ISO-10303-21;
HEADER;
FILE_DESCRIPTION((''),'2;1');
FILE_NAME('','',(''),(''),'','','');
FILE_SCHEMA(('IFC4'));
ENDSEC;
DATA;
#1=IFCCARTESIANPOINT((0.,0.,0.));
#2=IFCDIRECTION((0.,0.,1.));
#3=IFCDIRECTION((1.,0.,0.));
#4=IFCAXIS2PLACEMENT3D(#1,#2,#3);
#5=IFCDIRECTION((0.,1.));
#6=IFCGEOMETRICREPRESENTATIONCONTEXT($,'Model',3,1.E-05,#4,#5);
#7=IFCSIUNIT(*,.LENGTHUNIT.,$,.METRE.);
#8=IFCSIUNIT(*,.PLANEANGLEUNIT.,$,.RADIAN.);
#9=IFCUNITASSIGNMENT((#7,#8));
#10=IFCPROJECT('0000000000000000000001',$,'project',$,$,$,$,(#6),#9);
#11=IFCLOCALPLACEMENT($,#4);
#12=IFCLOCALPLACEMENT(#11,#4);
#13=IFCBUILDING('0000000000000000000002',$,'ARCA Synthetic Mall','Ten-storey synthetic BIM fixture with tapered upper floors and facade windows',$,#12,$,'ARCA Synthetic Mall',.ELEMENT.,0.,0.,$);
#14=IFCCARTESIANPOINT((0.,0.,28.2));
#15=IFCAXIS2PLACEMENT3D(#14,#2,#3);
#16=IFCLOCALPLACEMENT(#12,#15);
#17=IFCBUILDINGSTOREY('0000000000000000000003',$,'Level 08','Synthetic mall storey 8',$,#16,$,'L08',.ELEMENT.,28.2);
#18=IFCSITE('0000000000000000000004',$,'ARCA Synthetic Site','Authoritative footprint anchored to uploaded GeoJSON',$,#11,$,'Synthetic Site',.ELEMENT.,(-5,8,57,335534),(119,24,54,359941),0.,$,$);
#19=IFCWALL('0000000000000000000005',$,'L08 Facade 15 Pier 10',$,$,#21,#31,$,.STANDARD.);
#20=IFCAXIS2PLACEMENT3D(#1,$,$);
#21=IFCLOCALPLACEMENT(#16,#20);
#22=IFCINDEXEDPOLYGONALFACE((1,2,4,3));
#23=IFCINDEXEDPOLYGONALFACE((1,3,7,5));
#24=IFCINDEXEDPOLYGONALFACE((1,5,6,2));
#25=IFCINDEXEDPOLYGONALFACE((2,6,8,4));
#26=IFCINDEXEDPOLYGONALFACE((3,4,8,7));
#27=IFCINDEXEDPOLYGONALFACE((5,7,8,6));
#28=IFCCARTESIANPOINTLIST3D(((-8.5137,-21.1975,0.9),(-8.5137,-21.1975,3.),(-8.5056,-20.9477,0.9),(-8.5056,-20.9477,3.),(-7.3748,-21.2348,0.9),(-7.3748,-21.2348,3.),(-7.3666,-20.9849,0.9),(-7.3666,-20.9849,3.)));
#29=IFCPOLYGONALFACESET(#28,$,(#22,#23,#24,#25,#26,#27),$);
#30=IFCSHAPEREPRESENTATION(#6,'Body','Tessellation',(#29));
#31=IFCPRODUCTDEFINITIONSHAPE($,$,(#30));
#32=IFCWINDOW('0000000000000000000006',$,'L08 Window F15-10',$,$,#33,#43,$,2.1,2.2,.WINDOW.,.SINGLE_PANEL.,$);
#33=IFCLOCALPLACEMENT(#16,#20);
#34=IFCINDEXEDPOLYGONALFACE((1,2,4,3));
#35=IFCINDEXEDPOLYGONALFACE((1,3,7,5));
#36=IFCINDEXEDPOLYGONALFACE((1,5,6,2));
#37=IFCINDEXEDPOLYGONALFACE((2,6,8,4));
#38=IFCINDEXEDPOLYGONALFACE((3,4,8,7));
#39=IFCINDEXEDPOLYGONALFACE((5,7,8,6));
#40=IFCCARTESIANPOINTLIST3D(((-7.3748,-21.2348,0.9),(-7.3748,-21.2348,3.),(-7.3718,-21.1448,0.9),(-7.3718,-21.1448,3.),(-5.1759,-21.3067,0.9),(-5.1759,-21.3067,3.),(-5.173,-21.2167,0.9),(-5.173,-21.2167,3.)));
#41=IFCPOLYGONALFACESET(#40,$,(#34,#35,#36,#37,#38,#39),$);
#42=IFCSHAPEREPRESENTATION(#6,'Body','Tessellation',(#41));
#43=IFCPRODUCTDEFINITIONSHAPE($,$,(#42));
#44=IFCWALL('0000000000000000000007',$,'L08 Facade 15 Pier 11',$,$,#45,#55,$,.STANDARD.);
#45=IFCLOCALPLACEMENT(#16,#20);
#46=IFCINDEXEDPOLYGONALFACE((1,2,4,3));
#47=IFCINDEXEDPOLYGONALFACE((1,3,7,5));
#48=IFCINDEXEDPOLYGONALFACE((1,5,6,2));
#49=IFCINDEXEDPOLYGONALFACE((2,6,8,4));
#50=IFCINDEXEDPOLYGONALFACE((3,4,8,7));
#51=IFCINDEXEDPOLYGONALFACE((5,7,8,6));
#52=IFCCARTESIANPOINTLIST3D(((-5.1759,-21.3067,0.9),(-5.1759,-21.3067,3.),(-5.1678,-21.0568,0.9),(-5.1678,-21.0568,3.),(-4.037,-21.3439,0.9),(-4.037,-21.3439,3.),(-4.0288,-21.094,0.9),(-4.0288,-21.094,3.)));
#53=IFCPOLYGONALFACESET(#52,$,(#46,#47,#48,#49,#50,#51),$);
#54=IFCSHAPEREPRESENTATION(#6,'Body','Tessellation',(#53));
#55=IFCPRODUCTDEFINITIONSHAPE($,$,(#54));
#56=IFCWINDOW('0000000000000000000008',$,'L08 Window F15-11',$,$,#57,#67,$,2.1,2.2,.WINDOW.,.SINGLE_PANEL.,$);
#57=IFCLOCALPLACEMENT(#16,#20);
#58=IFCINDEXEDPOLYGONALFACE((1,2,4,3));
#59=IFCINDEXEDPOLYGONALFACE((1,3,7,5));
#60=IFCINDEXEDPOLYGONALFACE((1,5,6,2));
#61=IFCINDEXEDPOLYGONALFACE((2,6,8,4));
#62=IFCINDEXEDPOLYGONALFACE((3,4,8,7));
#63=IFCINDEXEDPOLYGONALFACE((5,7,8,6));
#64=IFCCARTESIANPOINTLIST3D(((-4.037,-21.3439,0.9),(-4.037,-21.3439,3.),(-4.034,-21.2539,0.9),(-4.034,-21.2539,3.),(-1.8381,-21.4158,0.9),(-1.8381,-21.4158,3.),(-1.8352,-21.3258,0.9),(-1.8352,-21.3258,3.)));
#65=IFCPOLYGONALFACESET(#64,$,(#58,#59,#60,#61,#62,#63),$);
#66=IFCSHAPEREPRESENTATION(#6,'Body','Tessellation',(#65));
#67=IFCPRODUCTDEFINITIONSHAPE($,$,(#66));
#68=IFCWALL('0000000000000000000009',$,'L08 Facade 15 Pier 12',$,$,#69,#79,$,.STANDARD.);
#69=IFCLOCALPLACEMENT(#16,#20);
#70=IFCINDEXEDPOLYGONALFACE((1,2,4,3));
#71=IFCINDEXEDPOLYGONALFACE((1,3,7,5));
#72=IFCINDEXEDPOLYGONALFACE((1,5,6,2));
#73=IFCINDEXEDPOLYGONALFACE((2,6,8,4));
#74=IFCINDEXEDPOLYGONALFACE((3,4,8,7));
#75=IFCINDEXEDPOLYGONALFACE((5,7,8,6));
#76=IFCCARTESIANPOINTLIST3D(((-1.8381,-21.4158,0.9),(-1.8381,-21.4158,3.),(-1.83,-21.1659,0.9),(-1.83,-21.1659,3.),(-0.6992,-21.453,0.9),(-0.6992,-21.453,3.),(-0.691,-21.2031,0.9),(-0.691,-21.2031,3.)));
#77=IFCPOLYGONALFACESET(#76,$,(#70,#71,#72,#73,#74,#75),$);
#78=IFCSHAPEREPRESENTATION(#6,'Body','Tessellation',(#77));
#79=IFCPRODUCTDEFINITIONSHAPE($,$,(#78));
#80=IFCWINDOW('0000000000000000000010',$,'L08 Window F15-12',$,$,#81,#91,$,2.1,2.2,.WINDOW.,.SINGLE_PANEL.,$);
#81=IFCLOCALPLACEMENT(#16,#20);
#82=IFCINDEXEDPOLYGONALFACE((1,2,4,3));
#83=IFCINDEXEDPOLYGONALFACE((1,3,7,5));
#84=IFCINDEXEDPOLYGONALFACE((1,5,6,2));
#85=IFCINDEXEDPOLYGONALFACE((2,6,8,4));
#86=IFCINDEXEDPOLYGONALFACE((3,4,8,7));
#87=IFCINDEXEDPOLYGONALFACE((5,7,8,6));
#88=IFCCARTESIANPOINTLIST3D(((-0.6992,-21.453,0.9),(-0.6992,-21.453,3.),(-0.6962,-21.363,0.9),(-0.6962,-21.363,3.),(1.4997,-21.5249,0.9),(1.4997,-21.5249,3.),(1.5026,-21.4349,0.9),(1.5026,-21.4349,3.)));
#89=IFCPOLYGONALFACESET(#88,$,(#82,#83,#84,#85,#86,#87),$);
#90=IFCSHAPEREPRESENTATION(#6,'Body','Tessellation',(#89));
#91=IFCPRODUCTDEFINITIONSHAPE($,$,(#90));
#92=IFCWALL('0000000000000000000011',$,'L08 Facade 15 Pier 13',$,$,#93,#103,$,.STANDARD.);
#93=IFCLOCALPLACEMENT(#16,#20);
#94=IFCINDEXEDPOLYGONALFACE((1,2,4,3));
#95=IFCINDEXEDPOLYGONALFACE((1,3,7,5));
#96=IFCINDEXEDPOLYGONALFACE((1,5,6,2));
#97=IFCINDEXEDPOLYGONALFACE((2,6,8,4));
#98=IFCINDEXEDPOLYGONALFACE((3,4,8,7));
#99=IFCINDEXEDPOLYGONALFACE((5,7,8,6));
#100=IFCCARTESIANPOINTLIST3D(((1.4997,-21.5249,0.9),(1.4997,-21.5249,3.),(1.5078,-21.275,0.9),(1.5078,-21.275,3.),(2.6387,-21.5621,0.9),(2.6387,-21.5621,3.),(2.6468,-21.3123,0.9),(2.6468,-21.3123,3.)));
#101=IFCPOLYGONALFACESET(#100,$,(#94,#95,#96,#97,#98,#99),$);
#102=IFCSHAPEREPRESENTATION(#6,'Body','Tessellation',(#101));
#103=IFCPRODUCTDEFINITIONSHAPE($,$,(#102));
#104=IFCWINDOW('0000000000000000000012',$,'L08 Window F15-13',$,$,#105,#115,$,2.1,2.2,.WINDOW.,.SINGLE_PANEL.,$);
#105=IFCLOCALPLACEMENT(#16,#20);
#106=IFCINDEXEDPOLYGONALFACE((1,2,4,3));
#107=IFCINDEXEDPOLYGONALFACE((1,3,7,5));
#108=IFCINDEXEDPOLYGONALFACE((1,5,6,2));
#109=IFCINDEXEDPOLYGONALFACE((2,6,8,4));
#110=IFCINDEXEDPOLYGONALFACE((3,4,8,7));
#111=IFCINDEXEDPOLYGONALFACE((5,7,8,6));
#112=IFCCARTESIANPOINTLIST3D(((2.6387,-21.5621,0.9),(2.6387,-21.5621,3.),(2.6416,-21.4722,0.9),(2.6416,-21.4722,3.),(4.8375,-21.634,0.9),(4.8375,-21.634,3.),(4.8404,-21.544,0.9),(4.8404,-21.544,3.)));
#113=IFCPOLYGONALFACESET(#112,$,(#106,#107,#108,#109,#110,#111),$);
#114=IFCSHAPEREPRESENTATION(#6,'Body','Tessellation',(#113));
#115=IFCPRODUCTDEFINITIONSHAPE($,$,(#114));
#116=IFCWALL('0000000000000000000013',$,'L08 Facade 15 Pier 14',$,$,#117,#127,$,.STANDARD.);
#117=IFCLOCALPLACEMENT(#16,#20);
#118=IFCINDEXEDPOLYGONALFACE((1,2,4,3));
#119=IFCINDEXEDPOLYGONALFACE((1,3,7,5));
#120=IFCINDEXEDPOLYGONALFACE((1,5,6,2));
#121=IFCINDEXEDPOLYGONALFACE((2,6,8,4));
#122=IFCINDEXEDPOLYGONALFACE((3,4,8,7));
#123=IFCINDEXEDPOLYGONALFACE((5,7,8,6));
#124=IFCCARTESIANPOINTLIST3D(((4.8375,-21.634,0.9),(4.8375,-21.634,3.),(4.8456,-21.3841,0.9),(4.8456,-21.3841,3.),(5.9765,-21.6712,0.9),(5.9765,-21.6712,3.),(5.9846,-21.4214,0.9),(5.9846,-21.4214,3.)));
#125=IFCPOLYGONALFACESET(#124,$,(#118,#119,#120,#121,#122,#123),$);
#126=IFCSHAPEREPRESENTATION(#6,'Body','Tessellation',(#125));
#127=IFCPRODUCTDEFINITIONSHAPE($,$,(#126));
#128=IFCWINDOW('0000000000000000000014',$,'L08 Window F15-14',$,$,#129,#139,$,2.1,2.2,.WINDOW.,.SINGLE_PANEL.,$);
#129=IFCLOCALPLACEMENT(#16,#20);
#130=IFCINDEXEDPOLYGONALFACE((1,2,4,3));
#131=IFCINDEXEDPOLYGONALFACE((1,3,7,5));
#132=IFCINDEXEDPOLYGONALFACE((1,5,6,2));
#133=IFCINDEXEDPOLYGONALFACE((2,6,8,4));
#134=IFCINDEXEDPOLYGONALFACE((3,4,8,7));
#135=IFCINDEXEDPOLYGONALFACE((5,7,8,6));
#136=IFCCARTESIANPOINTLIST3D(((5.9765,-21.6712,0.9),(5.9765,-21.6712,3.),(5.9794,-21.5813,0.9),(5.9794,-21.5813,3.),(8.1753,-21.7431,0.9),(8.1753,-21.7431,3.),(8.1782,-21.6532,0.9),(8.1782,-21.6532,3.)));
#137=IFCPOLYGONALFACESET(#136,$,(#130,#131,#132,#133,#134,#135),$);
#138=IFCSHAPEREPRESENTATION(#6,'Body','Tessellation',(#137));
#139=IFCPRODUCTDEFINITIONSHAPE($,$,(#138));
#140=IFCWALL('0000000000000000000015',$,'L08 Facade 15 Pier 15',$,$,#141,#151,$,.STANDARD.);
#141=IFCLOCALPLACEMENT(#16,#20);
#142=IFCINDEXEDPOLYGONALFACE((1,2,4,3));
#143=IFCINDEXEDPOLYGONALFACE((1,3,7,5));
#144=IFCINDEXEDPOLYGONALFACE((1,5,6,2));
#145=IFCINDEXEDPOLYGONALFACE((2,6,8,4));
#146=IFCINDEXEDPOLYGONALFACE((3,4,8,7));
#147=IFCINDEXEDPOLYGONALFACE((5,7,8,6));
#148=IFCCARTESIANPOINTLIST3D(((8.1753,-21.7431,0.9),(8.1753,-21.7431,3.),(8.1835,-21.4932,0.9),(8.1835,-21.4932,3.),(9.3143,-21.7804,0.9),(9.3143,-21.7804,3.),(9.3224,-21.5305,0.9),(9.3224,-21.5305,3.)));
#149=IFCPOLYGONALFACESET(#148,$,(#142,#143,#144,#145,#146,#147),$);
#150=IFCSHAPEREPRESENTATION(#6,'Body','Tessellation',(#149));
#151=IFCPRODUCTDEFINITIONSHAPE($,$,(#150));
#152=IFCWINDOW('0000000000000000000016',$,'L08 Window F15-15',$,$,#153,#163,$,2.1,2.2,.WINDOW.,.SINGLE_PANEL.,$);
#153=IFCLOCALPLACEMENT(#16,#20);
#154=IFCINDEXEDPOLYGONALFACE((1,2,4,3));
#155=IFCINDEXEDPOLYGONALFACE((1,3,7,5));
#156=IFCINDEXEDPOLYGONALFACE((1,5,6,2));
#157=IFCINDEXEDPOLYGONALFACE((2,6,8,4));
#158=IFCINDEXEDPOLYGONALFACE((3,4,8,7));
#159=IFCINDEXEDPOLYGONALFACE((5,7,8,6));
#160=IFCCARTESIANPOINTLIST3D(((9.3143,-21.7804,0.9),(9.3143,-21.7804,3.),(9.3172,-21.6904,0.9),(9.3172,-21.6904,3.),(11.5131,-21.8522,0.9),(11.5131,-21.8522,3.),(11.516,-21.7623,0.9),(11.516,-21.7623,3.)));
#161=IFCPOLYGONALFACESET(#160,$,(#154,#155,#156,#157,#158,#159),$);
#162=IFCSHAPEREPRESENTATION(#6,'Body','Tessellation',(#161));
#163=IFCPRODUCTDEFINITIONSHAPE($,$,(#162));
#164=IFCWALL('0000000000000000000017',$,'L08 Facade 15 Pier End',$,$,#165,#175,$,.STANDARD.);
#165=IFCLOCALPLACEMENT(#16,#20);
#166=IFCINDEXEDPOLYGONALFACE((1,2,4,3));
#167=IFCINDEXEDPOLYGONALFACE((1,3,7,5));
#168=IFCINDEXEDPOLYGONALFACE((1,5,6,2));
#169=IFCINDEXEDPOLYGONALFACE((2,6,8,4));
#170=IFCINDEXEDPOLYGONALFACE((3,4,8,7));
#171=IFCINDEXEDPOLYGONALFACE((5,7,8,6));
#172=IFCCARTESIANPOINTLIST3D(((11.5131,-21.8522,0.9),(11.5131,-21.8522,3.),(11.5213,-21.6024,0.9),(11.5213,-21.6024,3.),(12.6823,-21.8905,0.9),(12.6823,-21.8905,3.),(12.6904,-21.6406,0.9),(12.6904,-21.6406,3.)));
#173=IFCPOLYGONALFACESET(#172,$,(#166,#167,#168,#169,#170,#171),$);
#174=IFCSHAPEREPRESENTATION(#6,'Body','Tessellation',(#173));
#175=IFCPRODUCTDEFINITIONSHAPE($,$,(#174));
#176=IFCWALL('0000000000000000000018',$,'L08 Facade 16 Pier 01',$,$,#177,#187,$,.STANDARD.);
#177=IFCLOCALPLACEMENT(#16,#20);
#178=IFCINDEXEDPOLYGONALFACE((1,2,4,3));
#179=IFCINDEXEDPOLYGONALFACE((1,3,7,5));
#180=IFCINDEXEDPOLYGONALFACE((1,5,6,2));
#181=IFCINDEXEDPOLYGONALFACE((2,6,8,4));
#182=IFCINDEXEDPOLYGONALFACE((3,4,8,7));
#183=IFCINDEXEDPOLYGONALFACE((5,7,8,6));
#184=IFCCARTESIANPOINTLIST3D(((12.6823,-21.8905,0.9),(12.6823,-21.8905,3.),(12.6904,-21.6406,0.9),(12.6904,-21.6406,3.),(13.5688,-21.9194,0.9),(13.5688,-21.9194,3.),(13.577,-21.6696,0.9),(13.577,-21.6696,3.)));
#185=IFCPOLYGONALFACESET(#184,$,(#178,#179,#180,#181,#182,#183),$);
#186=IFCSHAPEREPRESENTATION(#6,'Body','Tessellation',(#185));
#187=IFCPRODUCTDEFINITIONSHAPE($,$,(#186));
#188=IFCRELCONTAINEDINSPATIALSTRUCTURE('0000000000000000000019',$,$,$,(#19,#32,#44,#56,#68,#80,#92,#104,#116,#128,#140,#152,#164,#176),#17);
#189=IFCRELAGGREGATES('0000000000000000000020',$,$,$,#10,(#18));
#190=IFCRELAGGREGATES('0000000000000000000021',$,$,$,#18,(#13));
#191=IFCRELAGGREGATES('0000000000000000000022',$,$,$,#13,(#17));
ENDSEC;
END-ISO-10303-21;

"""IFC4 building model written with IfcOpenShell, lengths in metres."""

from ifc_helpers import new_model, si_unit, direction, frame, origin_with_axes, place, context, project, spatial, polyline, outline, extrude, element, save


model = new_model("IFC4")

# Units and contexts
model_context = context("Model", 3, precision=1e-05, world=origin_with_axes(), true_north=direction((0.0, 1.0)))
ifc_project = project(units=[si_unit("LENGTHUNIT", "METRE"), si_unit("PLANEANGLEUNIT", "RADIAN")], contexts=[model_context])

# Site, building, storey
site_placement = place(None, origin_with_axes())
site = spatial("IfcSite", under=ifc_project, at=site_placement, Name="ARCA Synthetic Site", Description="Authoritative footprint anchored to uploaded GeoJSON", LongName="Synthetic Site", CompositionType="ELEMENT", RefLatitude=(-5, 8, 57, 335534), RefLongitude=(119, 24, 54, 359941), RefElevation=0.0)
building_placement = place(site_placement, origin_with_axes())
building = spatial("IfcBuilding", under=site, at=building_placement, Name="ARCA Synthetic Mall", Description="Ten-storey synthetic BIM fixture with tapered upper floors and facade windows", LongName="ARCA Synthetic Mall", CompositionType="ELEMENT", ElevationOfRefHeight=0.0, ElevationOfTerrain=0.0)
storey_placement = place(building_placement, frame((0.0, 0.0, 28.2), z_axis=(0.0, 0.0, 1.0), x_axis=(1.0, 0.0, 0.0)))
storey = spatial("IfcBuildingStorey", under=building, at=storey_placement, Name="Level 08", Description="Synthetic mall storey 8", LongName="L08", CompositionType="ELEMENT", Elevation=28.2)

# Wall
wall_1_placement = place(storey_placement, frame((0.0, 0.0, 0.9), z_axis=(0.0, 0.0, 1.0), x_axis=(1.0, 0.0, 0.0)))
element("IfcWall", 1, at=wall_1_placement, inside=storey, Name="L08 Facade 15 Pier 10", PredefinedType="STANDARD", context=model_context, shape_type="SweptSolid", body=[
    extrude(outline(polyline([(-8.5137, -21.1975), (-7.3748, -21.2348), (-7.3666, -20.9849), (-8.5056, -20.9477), (-8.5137, -21.1975)])), origin_with_axes(), (0.0, 0.0, 1.0), 2.1),
])

# Window
window_1_placement = place(storey_placement, frame((0.0, 0.0, 0.9), z_axis=(0.0, 0.0, 1.0), x_axis=(1.0, 0.0, 0.0)))
element("IfcWindow", 2, at=window_1_placement, inside=storey, Name="L08 Window F15-10", OverallHeight=2.1, OverallWidth=2.2, PartitioningType="SINGLE_PANEL", PredefinedType="WINDOW", context=model_context, shape_type="SweptSolid", body=[
    extrude(outline(polyline([(-7.3748, -21.2348), (-5.1759, -21.3067), (-5.173, -21.2167), (-7.3718, -21.1448), (-7.3748, -21.2348)])), origin_with_axes(), (0.0, 0.0, 1.0), 2.1),
])

# Wall
wall_2_placement = place(storey_placement, frame((0.0, 0.0, 0.9), z_axis=(0.0, 0.0, 1.0), x_axis=(1.0, 0.0, 0.0)))
element("IfcWall", 3, at=wall_2_placement, inside=storey, Name="L08 Facade 15 Pier 11", PredefinedType="STANDARD", context=model_context, shape_type="SweptSolid", body=[
    extrude(outline(polyline([(-5.1759, -21.3067), (-4.037, -21.3439), (-4.0288, -21.094), (-5.1678, -21.0568), (-5.1759, -21.3067)])), origin_with_axes(), (0.0, 0.0, 1.0), 2.1),
])

# Window
window_2_placement = place(storey_placement, frame((0.0, 0.0, 0.9), z_axis=(0.0, 0.0, 1.0), x_axis=(1.0, 0.0, 0.0)))
element("IfcWindow", 4, at=window_2_placement, inside=storey, Name="L08 Window F15-11", OverallHeight=2.1, OverallWidth=2.2, PartitioningType="SINGLE_PANEL", PredefinedType="WINDOW", context=model_context, shape_type="SweptSolid", body=[
    extrude(outline(polyline([(-4.037, -21.3439), (-1.8381, -21.4158), (-1.8352, -21.3258), (-4.034, -21.2539), (-4.037, -21.3439)])), origin_with_axes(), (0.0, 0.0, 1.0), 2.1),
])

# Wall
wall_3_placement = place(storey_placement, frame((0.0, 0.0, 0.9), z_axis=(0.0, 0.0, 1.0), x_axis=(1.0, 0.0, 0.0)))
element("IfcWall", 5, at=wall_3_placement, inside=storey, Name="L08 Facade 15 Pier 12", PredefinedType="STANDARD", context=model_context, shape_type="SweptSolid", body=[
    extrude(outline(polyline([(-1.8381, -21.4158), (-0.6992, -21.453), (-0.691, -21.2031), (-1.83, -21.1659), (-1.8381, -21.4158)])), origin_with_axes(), (0.0, 0.0, 1.0), 2.1),
])

# Window
window_3_placement = place(storey_placement, frame((0.0, 0.0, 0.9), z_axis=(0.0, 0.0, 1.0), x_axis=(1.0, 0.0, 0.0)))
element("IfcWindow", 6, at=window_3_placement, inside=storey, Name="L08 Window F15-12", OverallHeight=2.1, OverallWidth=2.2, PartitioningType="SINGLE_PANEL", PredefinedType="WINDOW", context=model_context, shape_type="SweptSolid", body=[
    extrude(outline(polyline([(-0.6992, -21.453), (1.4997, -21.5249), (1.5026, -21.4349), (-0.6962, -21.3631), (-0.6992, -21.453)])), origin_with_axes(), (0.0, 0.0, 1.0), 2.1),
])

# Wall
wall_4_placement = place(storey_placement, frame((0.0, 0.0, 0.9), z_axis=(0.0, 0.0, 1.0), x_axis=(1.0, 0.0, 0.0)))
element("IfcWall", 7, at=wall_4_placement, inside=storey, Name="L08 Facade 15 Pier 13", PredefinedType="STANDARD", context=model_context, shape_type="SweptSolid", body=[
    extrude(outline(polyline([(1.4997, -21.5249), (2.6387, -21.5621), (2.6468, -21.3123), (1.5078, -21.275), (1.4997, -21.5249)])), origin_with_axes(), (0.0, 0.0, 1.0), 2.1),
])

# Window
window_4_placement = place(storey_placement, frame((0.0, 0.0, 0.9), z_axis=(0.0, 0.0, 1.0), x_axis=(1.0, 0.0, 0.0)))
element("IfcWindow", 8, at=window_4_placement, inside=storey, Name="L08 Window F15-13", OverallHeight=2.1, OverallWidth=2.2, PartitioningType="SINGLE_PANEL", PredefinedType="WINDOW", context=model_context, shape_type="SweptSolid", body=[
    extrude(outline(polyline([(2.6387, -21.5621), (4.8375, -21.634), (4.8404, -21.544), (2.6416, -21.4722), (2.6387, -21.5621)])), origin_with_axes(), (0.0, 0.0, 1.0), 2.1),
])

# Wall
wall_5_placement = place(storey_placement, frame((0.0, 0.0, 0.9), z_axis=(0.0, 0.0, 1.0), x_axis=(1.0, 0.0, 0.0)))
element("IfcWall", 9, at=wall_5_placement, inside=storey, Name="L08 Facade 15 Pier 14", PredefinedType="STANDARD", context=model_context, shape_type="SweptSolid", body=[
    extrude(outline(polyline([(4.8375, -21.634), (5.9765, -21.6712), (5.9846, -21.4214), (4.8456, -21.3841), (4.8375, -21.634)])), origin_with_axes(), (0.0, 0.0, 1.0), 2.1),
])

# Window
window_5_placement = place(storey_placement, frame((0.0, 0.0, 0.9), z_axis=(0.0, 0.0, 1.0), x_axis=(1.0, 0.0, 0.0)))
element("IfcWindow", 10, at=window_5_placement, inside=storey, Name="L08 Window F15-14", OverallHeight=2.1, OverallWidth=2.2, PartitioningType="SINGLE_PANEL", PredefinedType="WINDOW", context=model_context, shape_type="SweptSolid", body=[
    extrude(outline(polyline([(5.9765, -21.6712), (8.1753, -21.7431), (8.1782, -21.6532), (5.9794, -21.5813), (5.9765, -21.6712)])), origin_with_axes(), (0.0, 0.0, 1.0), 2.1),
])

# Wall
wall_6_placement = place(storey_placement, frame((0.0, 0.0, 0.9), z_axis=(0.0, 0.0, 1.0), x_axis=(1.0, 0.0, 0.0)))
element("IfcWall", 11, at=wall_6_placement, inside=storey, Name="L08 Facade 15 Pier 15", PredefinedType="STANDARD", context=model_context, shape_type="SweptSolid", body=[
    extrude(outline(polyline([(8.1753, -21.7431), (9.3143, -21.7804), (9.3224, -21.5305), (8.1835, -21.4932), (8.1753, -21.7431)])), origin_with_axes(), (0.0, 0.0, 1.0), 2.1),
])

# Window
window_6_placement = place(storey_placement, frame((0.0, 0.0, 0.9), z_axis=(0.0, 0.0, 1.0), x_axis=(1.0, 0.0, 0.0)))
element("IfcWindow", 12, at=window_6_placement, inside=storey, Name="L08 Window F15-15", OverallHeight=2.1, OverallWidth=2.2, PartitioningType="SINGLE_PANEL", PredefinedType="WINDOW", context=model_context, shape_type="SweptSolid", body=[
    extrude(outline(polyline([(9.3143, -21.7804), (11.5131, -21.8522), (11.516, -21.7623), (9.3172, -21.6904), (9.3143, -21.7804)])), origin_with_axes(), (0.0, 0.0, 1.0), 2.1),
])

# Walls
wall_7_placement = place(storey_placement, frame((0.0, 0.0, 0.9), z_axis=(0.0, 0.0, 1.0), x_axis=(1.0, 0.0, 0.0)))
element("IfcWall", 13, at=wall_7_placement, inside=storey, Name="L08 Facade 15 Pier End", PredefinedType="STANDARD", context=model_context, shape_type="SweptSolid", body=[
    extrude(outline(polyline([(11.5131, -21.8522), (12.6823, -21.8905), (12.6904, -21.6406), (11.5213, -21.6024), (11.5131, -21.8522)])), origin_with_axes(), (0.0, 0.0, 1.0), 2.1),
])
wall_8_placement = place(storey_placement, frame((0.0, 0.0, 0.9), z_axis=(0.0, 0.0, 1.0), x_axis=(1.0, 0.0, 0.0)))
element("IfcWall", 14, at=wall_8_placement, inside=storey, Name="L08 Facade 16 Pier 01", PredefinedType="STANDARD", context=model_context, shape_type="SweptSolid", body=[
    extrude(outline(polyline([(12.6823, -21.8905), (13.5688, -21.9194), (13.577, -21.6696), (12.6904, -21.6406), (12.6823, -21.8905)])), origin_with_axes(), (0.0, 0.0, 1.0), 2.1),
])

save(model, "model.ifc")
